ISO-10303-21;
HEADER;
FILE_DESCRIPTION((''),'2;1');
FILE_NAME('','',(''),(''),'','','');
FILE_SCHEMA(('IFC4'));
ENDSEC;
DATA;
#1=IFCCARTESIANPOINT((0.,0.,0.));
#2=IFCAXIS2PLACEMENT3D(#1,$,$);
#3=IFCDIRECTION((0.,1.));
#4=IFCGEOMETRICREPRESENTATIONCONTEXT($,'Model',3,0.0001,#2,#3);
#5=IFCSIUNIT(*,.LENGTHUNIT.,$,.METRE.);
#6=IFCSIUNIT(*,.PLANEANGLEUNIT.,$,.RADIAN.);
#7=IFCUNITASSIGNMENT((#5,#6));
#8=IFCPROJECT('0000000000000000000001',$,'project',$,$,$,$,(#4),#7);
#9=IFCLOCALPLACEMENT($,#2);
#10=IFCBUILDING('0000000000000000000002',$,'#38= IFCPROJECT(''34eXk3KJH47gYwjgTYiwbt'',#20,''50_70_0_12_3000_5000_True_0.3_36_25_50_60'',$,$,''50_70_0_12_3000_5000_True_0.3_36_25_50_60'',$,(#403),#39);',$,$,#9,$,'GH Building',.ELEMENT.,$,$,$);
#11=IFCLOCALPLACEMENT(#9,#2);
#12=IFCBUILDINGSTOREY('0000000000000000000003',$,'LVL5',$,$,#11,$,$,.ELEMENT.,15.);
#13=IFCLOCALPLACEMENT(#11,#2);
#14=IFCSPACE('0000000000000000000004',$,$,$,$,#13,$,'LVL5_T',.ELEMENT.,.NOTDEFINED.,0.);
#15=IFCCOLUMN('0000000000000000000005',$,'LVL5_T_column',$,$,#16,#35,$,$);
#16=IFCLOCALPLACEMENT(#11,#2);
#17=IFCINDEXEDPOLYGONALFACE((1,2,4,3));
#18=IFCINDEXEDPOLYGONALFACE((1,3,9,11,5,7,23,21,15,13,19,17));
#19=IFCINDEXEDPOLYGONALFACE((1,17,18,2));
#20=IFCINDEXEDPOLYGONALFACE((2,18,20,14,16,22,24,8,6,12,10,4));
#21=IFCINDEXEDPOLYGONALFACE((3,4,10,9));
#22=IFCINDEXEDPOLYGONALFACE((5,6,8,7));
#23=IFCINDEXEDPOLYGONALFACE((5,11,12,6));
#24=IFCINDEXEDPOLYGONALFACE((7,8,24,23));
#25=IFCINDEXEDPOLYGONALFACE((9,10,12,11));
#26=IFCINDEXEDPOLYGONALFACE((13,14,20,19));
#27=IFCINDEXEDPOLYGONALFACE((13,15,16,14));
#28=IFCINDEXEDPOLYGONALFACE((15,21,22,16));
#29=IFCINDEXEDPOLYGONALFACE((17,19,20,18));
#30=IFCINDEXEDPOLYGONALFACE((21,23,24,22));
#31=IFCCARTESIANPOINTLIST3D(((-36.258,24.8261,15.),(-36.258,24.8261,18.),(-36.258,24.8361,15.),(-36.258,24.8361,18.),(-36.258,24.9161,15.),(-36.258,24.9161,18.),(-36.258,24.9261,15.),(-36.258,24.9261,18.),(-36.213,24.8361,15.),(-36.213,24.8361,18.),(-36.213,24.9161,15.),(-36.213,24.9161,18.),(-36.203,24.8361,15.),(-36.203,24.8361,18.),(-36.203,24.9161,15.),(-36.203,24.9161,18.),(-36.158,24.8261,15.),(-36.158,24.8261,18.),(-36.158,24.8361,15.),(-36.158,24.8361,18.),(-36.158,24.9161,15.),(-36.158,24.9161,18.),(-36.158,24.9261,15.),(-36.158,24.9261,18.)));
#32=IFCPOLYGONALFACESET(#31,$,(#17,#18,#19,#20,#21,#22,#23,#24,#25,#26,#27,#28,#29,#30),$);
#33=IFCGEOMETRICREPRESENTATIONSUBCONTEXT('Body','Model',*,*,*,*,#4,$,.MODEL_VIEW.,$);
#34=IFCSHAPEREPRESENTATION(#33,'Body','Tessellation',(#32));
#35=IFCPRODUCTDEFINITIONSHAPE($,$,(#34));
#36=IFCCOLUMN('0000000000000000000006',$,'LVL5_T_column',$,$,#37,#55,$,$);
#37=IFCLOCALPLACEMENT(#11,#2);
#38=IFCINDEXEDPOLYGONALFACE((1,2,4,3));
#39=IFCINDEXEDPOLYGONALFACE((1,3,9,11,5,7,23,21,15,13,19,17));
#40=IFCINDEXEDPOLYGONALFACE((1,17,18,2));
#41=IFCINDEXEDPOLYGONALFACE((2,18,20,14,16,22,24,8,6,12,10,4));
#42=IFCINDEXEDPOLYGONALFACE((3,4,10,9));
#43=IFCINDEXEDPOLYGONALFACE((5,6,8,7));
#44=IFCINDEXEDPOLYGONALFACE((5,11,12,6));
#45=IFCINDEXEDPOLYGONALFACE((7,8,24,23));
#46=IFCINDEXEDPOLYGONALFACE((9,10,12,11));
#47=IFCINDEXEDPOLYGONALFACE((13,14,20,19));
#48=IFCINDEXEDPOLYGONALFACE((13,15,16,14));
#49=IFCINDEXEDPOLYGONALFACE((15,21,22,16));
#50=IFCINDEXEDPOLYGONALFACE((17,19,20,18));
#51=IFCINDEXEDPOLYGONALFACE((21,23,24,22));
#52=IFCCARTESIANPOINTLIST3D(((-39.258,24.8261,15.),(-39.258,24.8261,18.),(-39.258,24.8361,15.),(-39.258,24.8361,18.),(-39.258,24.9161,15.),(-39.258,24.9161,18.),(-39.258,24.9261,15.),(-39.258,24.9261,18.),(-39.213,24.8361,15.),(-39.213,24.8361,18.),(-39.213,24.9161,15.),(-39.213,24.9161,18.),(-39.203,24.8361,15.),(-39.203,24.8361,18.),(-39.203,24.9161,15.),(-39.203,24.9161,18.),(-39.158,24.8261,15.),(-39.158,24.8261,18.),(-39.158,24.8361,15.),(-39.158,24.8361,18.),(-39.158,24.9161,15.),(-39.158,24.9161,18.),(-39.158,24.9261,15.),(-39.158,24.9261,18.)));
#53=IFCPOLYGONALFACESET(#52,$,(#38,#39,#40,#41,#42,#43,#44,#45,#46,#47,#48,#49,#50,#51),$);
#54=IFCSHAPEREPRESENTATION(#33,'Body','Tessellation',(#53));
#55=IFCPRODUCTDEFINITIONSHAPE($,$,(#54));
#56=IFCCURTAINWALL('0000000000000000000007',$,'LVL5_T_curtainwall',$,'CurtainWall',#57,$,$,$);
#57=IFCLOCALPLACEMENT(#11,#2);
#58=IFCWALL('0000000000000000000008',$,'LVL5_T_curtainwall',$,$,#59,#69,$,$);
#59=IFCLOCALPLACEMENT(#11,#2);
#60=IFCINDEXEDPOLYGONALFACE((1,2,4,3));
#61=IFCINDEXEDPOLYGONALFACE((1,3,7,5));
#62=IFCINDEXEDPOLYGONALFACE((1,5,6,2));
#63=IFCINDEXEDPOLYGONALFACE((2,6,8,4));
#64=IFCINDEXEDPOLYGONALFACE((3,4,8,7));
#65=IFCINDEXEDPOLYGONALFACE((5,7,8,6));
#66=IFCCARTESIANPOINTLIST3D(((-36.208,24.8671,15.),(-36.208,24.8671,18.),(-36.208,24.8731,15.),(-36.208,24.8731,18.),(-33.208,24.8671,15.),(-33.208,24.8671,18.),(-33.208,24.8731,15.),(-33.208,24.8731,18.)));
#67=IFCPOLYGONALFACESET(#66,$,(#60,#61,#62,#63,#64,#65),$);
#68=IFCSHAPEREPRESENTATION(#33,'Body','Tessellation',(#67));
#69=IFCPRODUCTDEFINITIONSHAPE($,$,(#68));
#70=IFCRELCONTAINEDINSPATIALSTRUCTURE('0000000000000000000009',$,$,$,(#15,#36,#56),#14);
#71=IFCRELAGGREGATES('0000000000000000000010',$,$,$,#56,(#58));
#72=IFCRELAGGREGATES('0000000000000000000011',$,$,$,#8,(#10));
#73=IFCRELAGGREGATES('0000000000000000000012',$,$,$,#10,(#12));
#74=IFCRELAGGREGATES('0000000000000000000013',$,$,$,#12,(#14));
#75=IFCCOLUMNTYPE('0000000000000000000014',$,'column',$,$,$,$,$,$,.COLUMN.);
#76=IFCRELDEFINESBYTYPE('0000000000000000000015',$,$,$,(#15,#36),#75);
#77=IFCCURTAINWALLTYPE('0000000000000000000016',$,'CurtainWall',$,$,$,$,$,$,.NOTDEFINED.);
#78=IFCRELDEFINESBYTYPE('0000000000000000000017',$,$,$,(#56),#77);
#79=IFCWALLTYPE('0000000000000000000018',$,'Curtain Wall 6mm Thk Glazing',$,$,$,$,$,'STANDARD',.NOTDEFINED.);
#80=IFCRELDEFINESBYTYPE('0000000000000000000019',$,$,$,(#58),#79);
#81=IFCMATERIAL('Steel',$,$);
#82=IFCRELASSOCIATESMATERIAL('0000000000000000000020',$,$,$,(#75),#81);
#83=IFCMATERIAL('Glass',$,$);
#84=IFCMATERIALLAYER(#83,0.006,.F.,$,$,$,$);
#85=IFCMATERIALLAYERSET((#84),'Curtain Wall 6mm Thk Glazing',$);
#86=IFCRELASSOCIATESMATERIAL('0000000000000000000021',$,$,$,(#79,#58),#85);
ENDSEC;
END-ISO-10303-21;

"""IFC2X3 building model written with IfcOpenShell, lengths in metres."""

from ifc_helpers import new_model, si_unit, direction, frame, frame_2d, origin, origin_2d, place, context, subcontext, project, spatial, rectangle, i_section, extrude, material, layer, layer_set, layer_usage, type_object, element, aggregate, save


model = new_model("IFC2X3")

# Units and contexts
model_context = context("Model", 3, precision=0.0001, world=origin(), true_north=direction((0.0, 1.0)))
body_context = subcontext(model_context, "Body", "Model", "MODEL_VIEW")
ifc_project = project(units=[si_unit("LENGTHUNIT", "METRE"), si_unit("PLANEANGLEUNIT", "RADIAN")], contexts=[model_context])

# Building, storey, space
building_placement = place(None, origin())
building = spatial("IfcBuilding", under=ifc_project, at=building_placement, Name="#38= IFCPROJECT('34eXk3KJH47gYwjgTYiwbt',#20,'50_70_0_12_3000_5000_True_0.3_36_25_50_60',$,$,'50_70_0_12_3000_5000_True_0.3_36_25_50_60',$,(#403),#39);", LongName="GH Building", CompositionType="ELEMENT")
storey_placement = place(building_placement, origin())
storey = spatial("IfcBuildingStorey", under=building, at=storey_placement, Name="LVL5", CompositionType="ELEMENT", Elevation=15.0)
space_1_placement = place(storey_placement, origin())
space_1 = spatial("IfcSpace", under=storey, at=space_1_placement, LongName="LVL5_T", CompositionType="ELEMENT", InteriorOrExteriorSpace="NOTDEFINED", ElevationWithFlooring=0.0)

# Columns
ifc_material_1 = material(Name="Steel")
column_type = type_object("IfcColumnType", Name="column", PredefinedType="COLUMN", material=ifc_material_1)
for number, where, name in (
    (1, (-36.208, 24.8761, 15.0), "LVL5_T_column"),
    (2, (-39.208, 24.8761, 15.0), "LVL5_T_column"),
):
    element("IfcColumn", number, at=place(space_1_placement, frame(where)), inside=space_1, type_object=column_type, Name=name, context=body_context, shape_type="SweptSolid", body=[
        extrude(i_section(OverallWidth=0.1, OverallDepth=0.1, WebThickness=0.01, FlangeThickness=0.01, at=origin_2d()), origin(), (0.0, 0.0, 1.0), 3.0),
    ])

# Curtain wall, wall
curtain_wall_type = type_object("IfcCurtainWallType", Name="CurtainWall", PredefinedType="NOTDEFINED")
curtain_wall_1_placement = place(None, origin())
curtain_wall_1 = element("IfcCurtainWall", 3, at=curtain_wall_1_placement, inside=space_1, type_object=curtain_wall_type, Name="LVL5_T_curtainwall", ObjectType="CurtainWall")
ifc_material_2 = material(Name="Glass")
ifc_layer = layer(ifc_material_2, 0.006, ventilated=False)
ifc_layer_set = layer_set([ifc_layer], Name="Curtain Wall 6mm Thk Glazing")
ifc_layer_usage_1 = layer_usage(ifc_layer_set, "AXIS2", "NEGATIVE", -0.003)
wall_type = type_object("IfcWallType", Name="Curtain Wall 6mm Thk Glazing", ElementType="STANDARD", PredefinedType="NOTDEFINED", material=ifc_layer_set)
wall_1_placement = place(curtain_wall_1_placement, frame((-36.208, 24.8761, 15.0)))
wall_1 = element("IfcWall", 4, at=wall_1_placement, type_object=wall_type, material=ifc_layer_usage_1, Name="LVL5_T_curtainwall", context=body_context, shape_type="SweptSolid", body=[
    extrude(rectangle(XDim=3.0, YDim=0.006, at=frame_2d((1.5, -0.006))), origin(), (0.0, 0.0, 1.0), 3.0),
])
aggregate(curtain_wall_1, [wall_1])

save(model, "model.ifc")
